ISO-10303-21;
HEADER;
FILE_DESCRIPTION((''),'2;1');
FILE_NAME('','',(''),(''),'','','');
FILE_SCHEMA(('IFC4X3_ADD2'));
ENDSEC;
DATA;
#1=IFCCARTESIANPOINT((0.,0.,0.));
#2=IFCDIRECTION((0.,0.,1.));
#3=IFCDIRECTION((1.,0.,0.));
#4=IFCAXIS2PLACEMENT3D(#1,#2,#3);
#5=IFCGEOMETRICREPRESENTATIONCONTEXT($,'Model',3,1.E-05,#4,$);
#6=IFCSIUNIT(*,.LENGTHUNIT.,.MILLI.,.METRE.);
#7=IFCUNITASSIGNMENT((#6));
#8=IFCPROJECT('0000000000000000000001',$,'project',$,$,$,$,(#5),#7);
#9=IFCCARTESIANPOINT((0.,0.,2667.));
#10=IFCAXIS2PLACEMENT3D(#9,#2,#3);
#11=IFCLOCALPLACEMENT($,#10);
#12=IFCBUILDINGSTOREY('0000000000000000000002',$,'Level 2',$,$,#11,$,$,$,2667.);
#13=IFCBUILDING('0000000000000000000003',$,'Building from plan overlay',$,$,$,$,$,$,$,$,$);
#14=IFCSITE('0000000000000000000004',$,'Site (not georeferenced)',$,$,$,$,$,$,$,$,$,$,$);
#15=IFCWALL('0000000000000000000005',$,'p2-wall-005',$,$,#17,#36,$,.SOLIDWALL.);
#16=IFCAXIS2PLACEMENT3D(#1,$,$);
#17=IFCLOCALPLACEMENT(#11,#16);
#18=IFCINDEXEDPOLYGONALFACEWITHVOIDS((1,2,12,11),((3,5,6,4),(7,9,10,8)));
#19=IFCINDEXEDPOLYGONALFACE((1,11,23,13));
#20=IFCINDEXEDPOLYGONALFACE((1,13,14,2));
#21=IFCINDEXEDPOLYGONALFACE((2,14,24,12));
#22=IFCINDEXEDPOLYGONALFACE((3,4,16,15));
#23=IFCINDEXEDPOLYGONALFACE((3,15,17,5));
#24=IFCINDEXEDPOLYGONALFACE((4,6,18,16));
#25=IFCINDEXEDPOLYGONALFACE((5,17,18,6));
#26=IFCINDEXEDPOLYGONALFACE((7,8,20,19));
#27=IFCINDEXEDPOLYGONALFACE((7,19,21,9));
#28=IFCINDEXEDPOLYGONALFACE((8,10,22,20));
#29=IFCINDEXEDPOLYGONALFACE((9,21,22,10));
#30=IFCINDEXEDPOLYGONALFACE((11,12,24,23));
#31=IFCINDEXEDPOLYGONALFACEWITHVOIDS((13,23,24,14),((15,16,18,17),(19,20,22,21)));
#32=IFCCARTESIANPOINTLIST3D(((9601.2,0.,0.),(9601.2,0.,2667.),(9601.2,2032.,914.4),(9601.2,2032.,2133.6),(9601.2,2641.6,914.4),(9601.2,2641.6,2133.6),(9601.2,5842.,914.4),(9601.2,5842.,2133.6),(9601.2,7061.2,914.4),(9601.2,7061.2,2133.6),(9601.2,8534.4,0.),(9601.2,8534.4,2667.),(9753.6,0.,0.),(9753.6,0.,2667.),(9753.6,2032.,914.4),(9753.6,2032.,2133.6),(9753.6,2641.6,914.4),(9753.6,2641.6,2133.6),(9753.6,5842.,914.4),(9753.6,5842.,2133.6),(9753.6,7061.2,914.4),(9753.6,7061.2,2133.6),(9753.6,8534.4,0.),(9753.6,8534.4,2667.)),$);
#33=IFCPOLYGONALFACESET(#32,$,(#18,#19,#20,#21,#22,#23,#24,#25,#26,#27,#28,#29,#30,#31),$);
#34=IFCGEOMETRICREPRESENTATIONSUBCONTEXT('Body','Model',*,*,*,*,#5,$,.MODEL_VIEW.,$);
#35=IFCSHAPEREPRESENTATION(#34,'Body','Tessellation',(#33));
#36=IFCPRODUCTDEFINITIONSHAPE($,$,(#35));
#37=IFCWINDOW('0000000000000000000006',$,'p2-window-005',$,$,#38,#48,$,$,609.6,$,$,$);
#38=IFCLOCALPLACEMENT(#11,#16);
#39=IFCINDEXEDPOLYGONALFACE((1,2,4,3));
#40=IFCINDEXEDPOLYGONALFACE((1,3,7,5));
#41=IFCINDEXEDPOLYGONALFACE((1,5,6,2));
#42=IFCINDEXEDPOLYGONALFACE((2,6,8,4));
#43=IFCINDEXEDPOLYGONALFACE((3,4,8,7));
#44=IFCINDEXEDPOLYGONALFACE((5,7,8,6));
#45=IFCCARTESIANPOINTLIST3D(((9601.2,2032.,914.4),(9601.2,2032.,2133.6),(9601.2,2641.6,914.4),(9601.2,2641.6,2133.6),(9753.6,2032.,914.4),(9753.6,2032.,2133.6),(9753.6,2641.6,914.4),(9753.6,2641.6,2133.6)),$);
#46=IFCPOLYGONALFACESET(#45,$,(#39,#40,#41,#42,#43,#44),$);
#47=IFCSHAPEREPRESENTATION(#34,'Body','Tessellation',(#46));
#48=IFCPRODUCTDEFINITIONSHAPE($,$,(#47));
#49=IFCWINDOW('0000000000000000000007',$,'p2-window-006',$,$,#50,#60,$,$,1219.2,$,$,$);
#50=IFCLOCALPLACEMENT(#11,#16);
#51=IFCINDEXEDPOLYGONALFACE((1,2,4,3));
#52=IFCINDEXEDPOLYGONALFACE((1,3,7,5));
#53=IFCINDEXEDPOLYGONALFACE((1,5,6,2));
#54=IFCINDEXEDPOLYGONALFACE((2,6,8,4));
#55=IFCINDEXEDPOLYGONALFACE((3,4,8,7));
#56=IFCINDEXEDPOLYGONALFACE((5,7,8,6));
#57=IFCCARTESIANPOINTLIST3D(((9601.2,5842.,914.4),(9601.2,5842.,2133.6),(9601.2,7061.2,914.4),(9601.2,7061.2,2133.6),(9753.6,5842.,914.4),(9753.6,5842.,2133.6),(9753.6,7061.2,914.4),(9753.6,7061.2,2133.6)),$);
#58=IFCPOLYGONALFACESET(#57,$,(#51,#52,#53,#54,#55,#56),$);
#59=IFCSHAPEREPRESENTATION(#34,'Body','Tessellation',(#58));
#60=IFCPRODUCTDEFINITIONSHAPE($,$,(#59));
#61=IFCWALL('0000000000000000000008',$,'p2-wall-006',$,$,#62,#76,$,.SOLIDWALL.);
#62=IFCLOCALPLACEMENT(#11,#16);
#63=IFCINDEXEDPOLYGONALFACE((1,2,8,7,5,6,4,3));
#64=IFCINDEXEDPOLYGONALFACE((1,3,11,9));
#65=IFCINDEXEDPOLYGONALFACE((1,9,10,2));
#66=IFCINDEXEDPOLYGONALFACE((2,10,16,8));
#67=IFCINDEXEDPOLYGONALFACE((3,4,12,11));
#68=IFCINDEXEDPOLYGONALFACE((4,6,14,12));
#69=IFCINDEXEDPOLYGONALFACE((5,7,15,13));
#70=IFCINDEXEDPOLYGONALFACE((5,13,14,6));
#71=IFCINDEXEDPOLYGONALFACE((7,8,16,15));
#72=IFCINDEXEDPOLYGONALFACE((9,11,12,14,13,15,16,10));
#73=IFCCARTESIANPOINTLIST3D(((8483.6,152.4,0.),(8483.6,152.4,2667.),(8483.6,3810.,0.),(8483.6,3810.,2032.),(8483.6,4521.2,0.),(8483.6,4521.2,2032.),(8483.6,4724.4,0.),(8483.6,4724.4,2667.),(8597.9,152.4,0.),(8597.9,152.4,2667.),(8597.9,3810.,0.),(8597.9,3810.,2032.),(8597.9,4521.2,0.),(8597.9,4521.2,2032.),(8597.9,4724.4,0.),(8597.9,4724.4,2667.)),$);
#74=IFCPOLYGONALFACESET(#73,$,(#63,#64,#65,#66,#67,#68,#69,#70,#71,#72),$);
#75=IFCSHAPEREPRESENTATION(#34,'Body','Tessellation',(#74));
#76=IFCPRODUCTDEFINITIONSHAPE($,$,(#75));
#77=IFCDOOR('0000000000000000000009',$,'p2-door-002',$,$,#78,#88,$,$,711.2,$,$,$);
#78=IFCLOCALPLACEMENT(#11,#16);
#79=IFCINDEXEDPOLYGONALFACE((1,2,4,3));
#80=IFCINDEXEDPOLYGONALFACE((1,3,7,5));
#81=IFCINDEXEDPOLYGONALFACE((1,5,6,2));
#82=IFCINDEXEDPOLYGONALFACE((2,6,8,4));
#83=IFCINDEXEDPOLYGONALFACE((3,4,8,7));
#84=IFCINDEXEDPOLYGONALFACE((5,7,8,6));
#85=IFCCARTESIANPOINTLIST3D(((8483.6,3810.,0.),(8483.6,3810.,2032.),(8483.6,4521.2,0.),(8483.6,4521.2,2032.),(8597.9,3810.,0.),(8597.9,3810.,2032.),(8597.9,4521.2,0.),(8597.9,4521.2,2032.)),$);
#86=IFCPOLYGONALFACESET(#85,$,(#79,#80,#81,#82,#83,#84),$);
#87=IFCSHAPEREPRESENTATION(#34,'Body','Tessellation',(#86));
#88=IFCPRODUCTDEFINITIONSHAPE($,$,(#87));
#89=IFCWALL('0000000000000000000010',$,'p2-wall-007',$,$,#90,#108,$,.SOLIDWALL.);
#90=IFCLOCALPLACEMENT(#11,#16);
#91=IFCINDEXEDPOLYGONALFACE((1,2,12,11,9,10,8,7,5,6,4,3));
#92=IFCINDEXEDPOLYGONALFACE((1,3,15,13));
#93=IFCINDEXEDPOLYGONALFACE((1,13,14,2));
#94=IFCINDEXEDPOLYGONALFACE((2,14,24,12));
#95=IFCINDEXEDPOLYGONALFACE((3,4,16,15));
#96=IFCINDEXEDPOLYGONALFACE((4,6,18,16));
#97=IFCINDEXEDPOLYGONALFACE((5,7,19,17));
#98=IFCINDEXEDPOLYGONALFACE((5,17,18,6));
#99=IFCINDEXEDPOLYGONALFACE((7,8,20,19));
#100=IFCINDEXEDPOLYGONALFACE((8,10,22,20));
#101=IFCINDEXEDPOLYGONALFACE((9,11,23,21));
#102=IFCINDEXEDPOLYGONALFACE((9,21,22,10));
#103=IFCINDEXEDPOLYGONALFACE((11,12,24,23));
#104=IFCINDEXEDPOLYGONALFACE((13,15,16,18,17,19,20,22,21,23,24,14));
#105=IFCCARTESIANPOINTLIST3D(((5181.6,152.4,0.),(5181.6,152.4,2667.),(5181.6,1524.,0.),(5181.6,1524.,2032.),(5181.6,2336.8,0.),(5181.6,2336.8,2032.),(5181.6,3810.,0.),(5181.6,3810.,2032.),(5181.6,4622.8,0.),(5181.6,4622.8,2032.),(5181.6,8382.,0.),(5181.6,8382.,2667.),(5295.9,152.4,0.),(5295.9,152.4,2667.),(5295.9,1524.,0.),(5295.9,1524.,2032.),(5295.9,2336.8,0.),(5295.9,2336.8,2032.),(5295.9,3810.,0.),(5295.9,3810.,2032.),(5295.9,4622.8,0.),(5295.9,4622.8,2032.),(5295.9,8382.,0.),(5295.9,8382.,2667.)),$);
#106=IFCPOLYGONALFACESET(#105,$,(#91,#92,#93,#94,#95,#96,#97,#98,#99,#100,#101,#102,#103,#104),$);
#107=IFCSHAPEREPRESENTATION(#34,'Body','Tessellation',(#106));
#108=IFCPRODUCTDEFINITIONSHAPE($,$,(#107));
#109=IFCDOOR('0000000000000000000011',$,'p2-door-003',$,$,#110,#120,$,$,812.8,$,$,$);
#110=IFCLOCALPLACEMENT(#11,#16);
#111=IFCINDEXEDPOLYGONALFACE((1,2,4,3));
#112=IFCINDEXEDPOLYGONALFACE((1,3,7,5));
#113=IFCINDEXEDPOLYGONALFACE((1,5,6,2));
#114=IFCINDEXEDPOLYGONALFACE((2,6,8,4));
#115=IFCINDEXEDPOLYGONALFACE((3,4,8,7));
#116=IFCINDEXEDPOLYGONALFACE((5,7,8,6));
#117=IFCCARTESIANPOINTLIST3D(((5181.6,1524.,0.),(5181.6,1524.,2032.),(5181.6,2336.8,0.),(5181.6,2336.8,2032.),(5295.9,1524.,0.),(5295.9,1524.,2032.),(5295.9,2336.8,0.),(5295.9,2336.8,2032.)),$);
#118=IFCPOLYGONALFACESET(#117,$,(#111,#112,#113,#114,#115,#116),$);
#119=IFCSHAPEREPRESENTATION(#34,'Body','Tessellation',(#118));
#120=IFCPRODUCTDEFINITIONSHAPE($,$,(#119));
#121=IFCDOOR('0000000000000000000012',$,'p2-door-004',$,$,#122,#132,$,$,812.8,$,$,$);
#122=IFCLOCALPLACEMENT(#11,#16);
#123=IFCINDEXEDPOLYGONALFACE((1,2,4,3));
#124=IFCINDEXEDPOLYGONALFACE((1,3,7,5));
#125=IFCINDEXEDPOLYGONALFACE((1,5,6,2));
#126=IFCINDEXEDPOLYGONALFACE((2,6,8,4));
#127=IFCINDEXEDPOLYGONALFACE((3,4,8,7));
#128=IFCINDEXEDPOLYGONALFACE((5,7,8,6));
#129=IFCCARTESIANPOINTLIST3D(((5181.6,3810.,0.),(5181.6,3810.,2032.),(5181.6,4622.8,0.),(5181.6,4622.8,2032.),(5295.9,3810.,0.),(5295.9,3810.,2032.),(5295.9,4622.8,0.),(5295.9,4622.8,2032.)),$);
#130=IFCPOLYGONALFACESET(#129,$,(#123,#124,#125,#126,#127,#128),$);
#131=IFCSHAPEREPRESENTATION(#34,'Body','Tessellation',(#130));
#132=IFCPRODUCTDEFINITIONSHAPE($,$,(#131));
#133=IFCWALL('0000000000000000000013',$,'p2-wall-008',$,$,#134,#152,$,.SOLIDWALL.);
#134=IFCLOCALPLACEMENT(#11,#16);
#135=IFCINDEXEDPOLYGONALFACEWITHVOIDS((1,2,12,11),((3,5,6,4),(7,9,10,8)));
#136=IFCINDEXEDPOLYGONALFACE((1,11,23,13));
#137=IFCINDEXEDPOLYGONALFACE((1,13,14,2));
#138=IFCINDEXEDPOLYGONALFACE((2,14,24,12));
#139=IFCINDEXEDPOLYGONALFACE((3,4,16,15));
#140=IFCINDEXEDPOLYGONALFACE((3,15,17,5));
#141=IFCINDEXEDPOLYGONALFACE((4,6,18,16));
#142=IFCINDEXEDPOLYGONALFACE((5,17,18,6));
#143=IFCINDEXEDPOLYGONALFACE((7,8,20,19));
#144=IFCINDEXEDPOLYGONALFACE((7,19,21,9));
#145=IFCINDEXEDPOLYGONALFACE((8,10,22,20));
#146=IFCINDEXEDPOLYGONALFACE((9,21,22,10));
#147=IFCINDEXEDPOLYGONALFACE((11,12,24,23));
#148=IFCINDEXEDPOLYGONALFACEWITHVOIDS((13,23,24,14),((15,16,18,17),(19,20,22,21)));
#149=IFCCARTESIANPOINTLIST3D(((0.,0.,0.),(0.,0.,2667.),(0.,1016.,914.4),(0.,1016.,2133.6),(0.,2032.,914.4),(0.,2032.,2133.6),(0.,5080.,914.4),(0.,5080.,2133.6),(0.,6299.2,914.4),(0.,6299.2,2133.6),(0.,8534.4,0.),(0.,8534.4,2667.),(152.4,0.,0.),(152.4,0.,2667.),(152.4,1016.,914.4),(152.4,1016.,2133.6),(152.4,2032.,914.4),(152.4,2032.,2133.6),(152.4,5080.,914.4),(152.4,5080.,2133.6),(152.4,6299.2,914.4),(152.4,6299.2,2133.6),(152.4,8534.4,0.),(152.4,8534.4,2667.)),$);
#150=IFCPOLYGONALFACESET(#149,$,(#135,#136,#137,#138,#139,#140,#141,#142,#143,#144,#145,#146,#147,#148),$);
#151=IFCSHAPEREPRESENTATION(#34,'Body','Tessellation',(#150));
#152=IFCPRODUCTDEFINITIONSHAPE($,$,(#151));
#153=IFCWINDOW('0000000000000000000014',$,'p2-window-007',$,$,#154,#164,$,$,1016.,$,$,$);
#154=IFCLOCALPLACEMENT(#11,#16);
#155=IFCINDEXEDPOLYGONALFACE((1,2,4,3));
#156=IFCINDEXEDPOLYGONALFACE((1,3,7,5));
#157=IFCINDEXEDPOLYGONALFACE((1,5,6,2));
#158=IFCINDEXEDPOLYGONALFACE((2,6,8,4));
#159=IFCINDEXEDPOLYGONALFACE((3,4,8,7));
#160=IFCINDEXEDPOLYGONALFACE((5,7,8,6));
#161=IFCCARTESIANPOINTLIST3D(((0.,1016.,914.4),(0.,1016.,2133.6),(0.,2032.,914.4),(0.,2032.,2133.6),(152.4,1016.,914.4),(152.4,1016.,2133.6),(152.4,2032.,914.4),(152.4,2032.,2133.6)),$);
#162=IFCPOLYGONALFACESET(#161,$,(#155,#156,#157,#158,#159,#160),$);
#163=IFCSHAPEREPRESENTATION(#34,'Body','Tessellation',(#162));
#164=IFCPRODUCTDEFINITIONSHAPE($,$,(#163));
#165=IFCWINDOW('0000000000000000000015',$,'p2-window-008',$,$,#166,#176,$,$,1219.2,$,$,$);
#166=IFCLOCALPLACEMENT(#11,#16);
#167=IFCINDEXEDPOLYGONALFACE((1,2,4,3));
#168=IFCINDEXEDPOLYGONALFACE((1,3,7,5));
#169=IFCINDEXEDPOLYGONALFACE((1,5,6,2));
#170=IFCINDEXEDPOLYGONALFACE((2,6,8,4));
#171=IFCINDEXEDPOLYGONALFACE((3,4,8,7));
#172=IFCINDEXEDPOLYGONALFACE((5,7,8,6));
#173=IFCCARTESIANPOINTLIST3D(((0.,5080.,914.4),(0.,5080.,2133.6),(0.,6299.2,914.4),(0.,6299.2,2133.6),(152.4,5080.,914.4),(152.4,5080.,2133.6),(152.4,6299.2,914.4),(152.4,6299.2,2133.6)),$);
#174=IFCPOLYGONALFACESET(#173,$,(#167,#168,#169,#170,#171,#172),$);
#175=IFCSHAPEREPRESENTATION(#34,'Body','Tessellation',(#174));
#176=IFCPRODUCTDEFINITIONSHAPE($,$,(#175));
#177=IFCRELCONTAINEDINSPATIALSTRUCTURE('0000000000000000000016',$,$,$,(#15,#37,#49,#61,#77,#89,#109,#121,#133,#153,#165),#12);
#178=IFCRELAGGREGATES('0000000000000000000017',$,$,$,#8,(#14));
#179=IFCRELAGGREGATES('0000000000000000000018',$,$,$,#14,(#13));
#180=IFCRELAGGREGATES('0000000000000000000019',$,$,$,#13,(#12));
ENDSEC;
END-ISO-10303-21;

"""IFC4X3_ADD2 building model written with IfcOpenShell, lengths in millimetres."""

from ifc_helpers import new_model, si_unit, frame, origin, origin_with_axes, place, context, subcontext, project, spatial, polyline, outline, extrude, element, fill, save


model = new_model("IFC4X3_ADD2")

# Units and contexts
model_context = context("Model", 3, precision=1e-05, world=origin_with_axes())
body_context = subcontext(model_context, "Body", "Model", "MODEL_VIEW")
ifc_project = project(units=[si_unit("LENGTHUNIT", "METRE", prefix="MILLI")], contexts=[model_context])

# Site, building, storey
site = spatial("IfcSite", under=ifc_project, Name="Site (not georeferenced)")
building = spatial("IfcBuilding", under=site, Name="Building from plan overlay")
storey_placement = place(None, frame((0.0, 0.0, 2667.0), z_axis=(0.0, 0.0, 1.0), x_axis=(1.0, 0.0, 0.0)))
storey = spatial("IfcBuildingStorey", under=building, at=storey_placement, Name="Level 2", Elevation=2667.0)

# Wall, openings, windows
wall_1_placement = place(storey_placement, origin_with_axes())
wall_1 = element("IfcWall", 1, at=wall_1_placement, inside=storey, Name="p2-wall-005", PredefinedType="SOLIDWALL", context=body_context, shape_type="SweptSolid", body=[
    extrude(outline(polyline([(9753.6, 0.0), (9753.6, 8534.4), (9601.2, 8534.4), (9601.2, 0.0), (9753.6, 0.0)])), origin(), (0.0, 0.0, 1.0), 2667.0),
])
opening_1_placement = place(wall_1_placement, origin_with_axes())
opening_1 = element("IfcOpeningElement", 2, at=opening_1_placement, cuts=wall_1, context=body_context, shape_type="SweptSolid", body=[
    extrude(outline(polyline([(9753.6, 2032.0), (9753.6, 2641.6), (9601.2, 2641.6), (9601.2, 2032.0), (9753.6, 2032.0)])), frame((0.0, 0.0, 914.4)), (0.0, 0.0, 1.0), 1219.2),
])
opening_2_placement = place(wall_1_placement, origin_with_axes())
opening_2 = element("IfcOpeningElement", 3, at=opening_2_placement, cuts=wall_1, context=body_context, shape_type="SweptSolid", body=[
    extrude(outline(polyline([(9753.6, 5842.0), (9753.6, 7061.2), (9601.2, 7061.2), (9601.2, 5842.0), (9753.6, 5842.0)])), frame((0.0, 0.0, 914.4)), (0.0, 0.0, 1.0), 1219.2),
])
window_1_placement = place(storey_placement, origin_with_axes())
window_1 = element("IfcWindow", 4, at=window_1_placement, inside=storey, Name="p2-window-005", OverallWidth=609.6, context=body_context, shape_type="SweptSolid", body=[
    extrude(outline(polyline([(9753.6, 2032.0), (9753.6, 2641.6), (9601.2, 2641.6), (9601.2, 2032.0), (9753.6, 2032.0)])), frame((0.0, 0.0, 914.4)), (0.0, 0.0, 1.0), 1219.2),
])
fill(opening_1, window_1)
window_2_placement = place(storey_placement, origin_with_axes())
window_2 = element("IfcWindow", 5, at=window_2_placement, inside=storey, Name="p2-window-006", OverallWidth=1219.2, context=body_context, shape_type="SweptSolid", body=[
    extrude(outline(polyline([(9753.6, 5842.0), (9753.6, 7061.2), (9601.2, 7061.2), (9601.2, 5842.0), (9753.6, 5842.0)])), frame((0.0, 0.0, 914.4)), (0.0, 0.0, 1.0), 1219.2),
])
fill(opening_2, window_2)

# Wall, opening, door
wall_2_placement = place(storey_placement, origin_with_axes())
wall_2 = element("IfcWall", 6, at=wall_2_placement, inside=storey, Name="p2-wall-006", PredefinedType="SOLIDWALL", context=body_context, shape_type="SweptSolid", body=[
    extrude(outline(polyline([(8597.9, 152.4), (8597.9, 4724.4), (8483.6, 4724.4), (8483.6, 152.4), (8597.9, 152.4)])), origin(), (0.0, 0.0, 1.0), 2667.0),
])
opening_3_placement = place(wall_2_placement, origin_with_axes())
opening_3 = element("IfcOpeningElement", 7, at=opening_3_placement, cuts=wall_2, context=body_context, shape_type="SweptSolid", body=[
    extrude(outline(polyline([(8597.9, 3810.0), (8597.9, 4521.2), (8483.6, 4521.2), (8483.6, 3810.0), (8597.9, 3810.0)])), origin(), (0.0, 0.0, 1.0), 2032.0),
])
door_1_placement = place(storey_placement, origin_with_axes())
door_1 = element("IfcDoor", 8, at=door_1_placement, inside=storey, Name="p2-door-002", OverallWidth=711.2, context=body_context, shape_type="SweptSolid", body=[
    extrude(outline(polyline([(8597.9, 3810.0), (8597.9, 4521.2), (8483.6, 4521.2), (8483.6, 3810.0), (8597.9, 3810.0)])), origin(), (0.0, 0.0, 1.0), 2032.0),
])
fill(opening_3, door_1)

# Wall, openings, doors
wall_3_placement = place(storey_placement, origin_with_axes())
wall_3 = element("IfcWall", 9, at=wall_3_placement, inside=storey, Name="p2-wall-007", PredefinedType="SOLIDWALL", context=body_context, shape_type="SweptSolid", body=[
    extrude(outline(polyline([(5295.9, 152.4), (5295.9, 8382.0), (5181.6, 8382.0), (5181.6, 152.4), (5295.9, 152.4)])), origin(), (0.0, 0.0, 1.0), 2667.0),
])
opening_4_placement = place(wall_3_placement, origin_with_axes())
opening_4 = element("IfcOpeningElement", 10, at=opening_4_placement, cuts=wall_3, context=body_context, shape_type="SweptSolid", body=[
    extrude(outline(polyline([(5295.9, 1524.0), (5295.9, 2336.8), (5181.6, 2336.8), (5181.6, 1524.0), (5295.9, 1524.0)])), origin(), (0.0, 0.0, 1.0), 2032.0),
])
opening_5_placement = place(wall_3_placement, origin_with_axes())
opening_5 = element("IfcOpeningElement", 11, at=opening_5_placement, cuts=wall_3, context=body_context, shape_type="SweptSolid", body=[
    extrude(outline(polyline([(5295.9, 3810.0), (5295.9, 4622.8), (5181.6, 4622.8), (5181.6, 3810.0), (5295.9, 3810.0)])), origin(), (0.0, 0.0, 1.0), 2032.0),
])
door_2_placement = place(storey_placement, origin_with_axes())
door_2 = element("IfcDoor", 12, at=door_2_placement, inside=storey, Name="p2-door-003", OverallWidth=812.8, context=body_context, shape_type="SweptSolid", body=[
    extrude(outline(polyline([(5295.9, 1524.0), (5295.9, 2336.8), (5181.6, 2336.8), (5181.6, 1524.0), (5295.9, 1524.0)])), origin(), (0.0, 0.0, 1.0), 2032.0),
])
fill(opening_4, door_2)
door_3_placement = place(storey_placement, origin_with_axes())
door_3 = element("IfcDoor", 13, at=door_3_placement, inside=storey, Name="p2-door-004", OverallWidth=812.8, context=body_context, shape_type="SweptSolid", body=[
    extrude(outline(polyline([(5295.9, 3810.0), (5295.9, 4622.8), (5181.6, 4622.8), (5181.6, 3810.0), (5295.9, 3810.0)])), origin(), (0.0, 0.0, 1.0), 2032.0),
])
fill(opening_5, door_3)

# Wall, openings, windows
wall_4_placement = place(storey_placement, origin_with_axes())
wall_4 = element("IfcWall", 14, at=wall_4_placement, inside=storey, Name="p2-wall-008", PredefinedType="SOLIDWALL", context=body_context, shape_type="SweptSolid", body=[
    extrude(outline(polyline([(152.4, 0.0), (152.4, 8534.4), (0.0, 8534.4), (0.0, 0.0), (152.4, 0.0)])), origin(), (0.0, 0.0, 1.0), 2667.0),
])
opening_6_placement = place(wall_4_placement, origin_with_axes())
opening_6 = element("IfcOpeningElement", 15, at=opening_6_placement, cuts=wall_4, context=body_context, shape_type="SweptSolid", body=[
    extrude(outline(polyline([(152.4, 1016.0), (152.4, 2032.0), (0.0, 2032.0), (0.0, 1016.0), (152.4, 1016.0)])), frame((0.0, 0.0, 914.4)), (0.0, 0.0, 1.0), 1219.2),
])
opening_7_placement = place(wall_4_placement, origin_with_axes())
opening_7 = element("IfcOpeningElement", 16, at=opening_7_placement, cuts=wall_4, context=body_context, shape_type="SweptSolid", body=[
    extrude(outline(polyline([(152.4, 5080.0), (152.4, 6299.2), (0.0, 6299.2), (0.0, 5080.0), (152.4, 5080.0)])), frame((0.0, 0.0, 914.4)), (0.0, 0.0, 1.0), 1219.2),
])
window_3_placement = place(storey_placement, origin_with_axes())
window_3 = element("IfcWindow", 17, at=window_3_placement, inside=storey, Name="p2-window-007", OverallWidth=1016.0, context=body_context, shape_type="SweptSolid", body=[
    extrude(outline(polyline([(152.4, 1016.0), (152.4, 2032.0), (0.0, 2032.0), (0.0, 1016.0), (152.4, 1016.0)])), frame((0.0, 0.0, 914.4)), (0.0, 0.0, 1.0), 1219.2),
])
fill(opening_6, window_3)
window_4_placement = place(storey_placement, origin_with_axes())
window_4 = element("IfcWindow", 18, at=window_4_placement, inside=storey, Name="p2-window-008", OverallWidth=1219.2, context=body_context, shape_type="SweptSolid", body=[
    extrude(outline(polyline([(152.4, 5080.0), (152.4, 6299.2), (0.0, 6299.2), (0.0, 5080.0), (152.4, 5080.0)])), frame((0.0, 0.0, 914.4)), (0.0, 0.0, 1.0), 1219.2),
])
fill(opening_7, window_4)

save(model, "model.ifc")
